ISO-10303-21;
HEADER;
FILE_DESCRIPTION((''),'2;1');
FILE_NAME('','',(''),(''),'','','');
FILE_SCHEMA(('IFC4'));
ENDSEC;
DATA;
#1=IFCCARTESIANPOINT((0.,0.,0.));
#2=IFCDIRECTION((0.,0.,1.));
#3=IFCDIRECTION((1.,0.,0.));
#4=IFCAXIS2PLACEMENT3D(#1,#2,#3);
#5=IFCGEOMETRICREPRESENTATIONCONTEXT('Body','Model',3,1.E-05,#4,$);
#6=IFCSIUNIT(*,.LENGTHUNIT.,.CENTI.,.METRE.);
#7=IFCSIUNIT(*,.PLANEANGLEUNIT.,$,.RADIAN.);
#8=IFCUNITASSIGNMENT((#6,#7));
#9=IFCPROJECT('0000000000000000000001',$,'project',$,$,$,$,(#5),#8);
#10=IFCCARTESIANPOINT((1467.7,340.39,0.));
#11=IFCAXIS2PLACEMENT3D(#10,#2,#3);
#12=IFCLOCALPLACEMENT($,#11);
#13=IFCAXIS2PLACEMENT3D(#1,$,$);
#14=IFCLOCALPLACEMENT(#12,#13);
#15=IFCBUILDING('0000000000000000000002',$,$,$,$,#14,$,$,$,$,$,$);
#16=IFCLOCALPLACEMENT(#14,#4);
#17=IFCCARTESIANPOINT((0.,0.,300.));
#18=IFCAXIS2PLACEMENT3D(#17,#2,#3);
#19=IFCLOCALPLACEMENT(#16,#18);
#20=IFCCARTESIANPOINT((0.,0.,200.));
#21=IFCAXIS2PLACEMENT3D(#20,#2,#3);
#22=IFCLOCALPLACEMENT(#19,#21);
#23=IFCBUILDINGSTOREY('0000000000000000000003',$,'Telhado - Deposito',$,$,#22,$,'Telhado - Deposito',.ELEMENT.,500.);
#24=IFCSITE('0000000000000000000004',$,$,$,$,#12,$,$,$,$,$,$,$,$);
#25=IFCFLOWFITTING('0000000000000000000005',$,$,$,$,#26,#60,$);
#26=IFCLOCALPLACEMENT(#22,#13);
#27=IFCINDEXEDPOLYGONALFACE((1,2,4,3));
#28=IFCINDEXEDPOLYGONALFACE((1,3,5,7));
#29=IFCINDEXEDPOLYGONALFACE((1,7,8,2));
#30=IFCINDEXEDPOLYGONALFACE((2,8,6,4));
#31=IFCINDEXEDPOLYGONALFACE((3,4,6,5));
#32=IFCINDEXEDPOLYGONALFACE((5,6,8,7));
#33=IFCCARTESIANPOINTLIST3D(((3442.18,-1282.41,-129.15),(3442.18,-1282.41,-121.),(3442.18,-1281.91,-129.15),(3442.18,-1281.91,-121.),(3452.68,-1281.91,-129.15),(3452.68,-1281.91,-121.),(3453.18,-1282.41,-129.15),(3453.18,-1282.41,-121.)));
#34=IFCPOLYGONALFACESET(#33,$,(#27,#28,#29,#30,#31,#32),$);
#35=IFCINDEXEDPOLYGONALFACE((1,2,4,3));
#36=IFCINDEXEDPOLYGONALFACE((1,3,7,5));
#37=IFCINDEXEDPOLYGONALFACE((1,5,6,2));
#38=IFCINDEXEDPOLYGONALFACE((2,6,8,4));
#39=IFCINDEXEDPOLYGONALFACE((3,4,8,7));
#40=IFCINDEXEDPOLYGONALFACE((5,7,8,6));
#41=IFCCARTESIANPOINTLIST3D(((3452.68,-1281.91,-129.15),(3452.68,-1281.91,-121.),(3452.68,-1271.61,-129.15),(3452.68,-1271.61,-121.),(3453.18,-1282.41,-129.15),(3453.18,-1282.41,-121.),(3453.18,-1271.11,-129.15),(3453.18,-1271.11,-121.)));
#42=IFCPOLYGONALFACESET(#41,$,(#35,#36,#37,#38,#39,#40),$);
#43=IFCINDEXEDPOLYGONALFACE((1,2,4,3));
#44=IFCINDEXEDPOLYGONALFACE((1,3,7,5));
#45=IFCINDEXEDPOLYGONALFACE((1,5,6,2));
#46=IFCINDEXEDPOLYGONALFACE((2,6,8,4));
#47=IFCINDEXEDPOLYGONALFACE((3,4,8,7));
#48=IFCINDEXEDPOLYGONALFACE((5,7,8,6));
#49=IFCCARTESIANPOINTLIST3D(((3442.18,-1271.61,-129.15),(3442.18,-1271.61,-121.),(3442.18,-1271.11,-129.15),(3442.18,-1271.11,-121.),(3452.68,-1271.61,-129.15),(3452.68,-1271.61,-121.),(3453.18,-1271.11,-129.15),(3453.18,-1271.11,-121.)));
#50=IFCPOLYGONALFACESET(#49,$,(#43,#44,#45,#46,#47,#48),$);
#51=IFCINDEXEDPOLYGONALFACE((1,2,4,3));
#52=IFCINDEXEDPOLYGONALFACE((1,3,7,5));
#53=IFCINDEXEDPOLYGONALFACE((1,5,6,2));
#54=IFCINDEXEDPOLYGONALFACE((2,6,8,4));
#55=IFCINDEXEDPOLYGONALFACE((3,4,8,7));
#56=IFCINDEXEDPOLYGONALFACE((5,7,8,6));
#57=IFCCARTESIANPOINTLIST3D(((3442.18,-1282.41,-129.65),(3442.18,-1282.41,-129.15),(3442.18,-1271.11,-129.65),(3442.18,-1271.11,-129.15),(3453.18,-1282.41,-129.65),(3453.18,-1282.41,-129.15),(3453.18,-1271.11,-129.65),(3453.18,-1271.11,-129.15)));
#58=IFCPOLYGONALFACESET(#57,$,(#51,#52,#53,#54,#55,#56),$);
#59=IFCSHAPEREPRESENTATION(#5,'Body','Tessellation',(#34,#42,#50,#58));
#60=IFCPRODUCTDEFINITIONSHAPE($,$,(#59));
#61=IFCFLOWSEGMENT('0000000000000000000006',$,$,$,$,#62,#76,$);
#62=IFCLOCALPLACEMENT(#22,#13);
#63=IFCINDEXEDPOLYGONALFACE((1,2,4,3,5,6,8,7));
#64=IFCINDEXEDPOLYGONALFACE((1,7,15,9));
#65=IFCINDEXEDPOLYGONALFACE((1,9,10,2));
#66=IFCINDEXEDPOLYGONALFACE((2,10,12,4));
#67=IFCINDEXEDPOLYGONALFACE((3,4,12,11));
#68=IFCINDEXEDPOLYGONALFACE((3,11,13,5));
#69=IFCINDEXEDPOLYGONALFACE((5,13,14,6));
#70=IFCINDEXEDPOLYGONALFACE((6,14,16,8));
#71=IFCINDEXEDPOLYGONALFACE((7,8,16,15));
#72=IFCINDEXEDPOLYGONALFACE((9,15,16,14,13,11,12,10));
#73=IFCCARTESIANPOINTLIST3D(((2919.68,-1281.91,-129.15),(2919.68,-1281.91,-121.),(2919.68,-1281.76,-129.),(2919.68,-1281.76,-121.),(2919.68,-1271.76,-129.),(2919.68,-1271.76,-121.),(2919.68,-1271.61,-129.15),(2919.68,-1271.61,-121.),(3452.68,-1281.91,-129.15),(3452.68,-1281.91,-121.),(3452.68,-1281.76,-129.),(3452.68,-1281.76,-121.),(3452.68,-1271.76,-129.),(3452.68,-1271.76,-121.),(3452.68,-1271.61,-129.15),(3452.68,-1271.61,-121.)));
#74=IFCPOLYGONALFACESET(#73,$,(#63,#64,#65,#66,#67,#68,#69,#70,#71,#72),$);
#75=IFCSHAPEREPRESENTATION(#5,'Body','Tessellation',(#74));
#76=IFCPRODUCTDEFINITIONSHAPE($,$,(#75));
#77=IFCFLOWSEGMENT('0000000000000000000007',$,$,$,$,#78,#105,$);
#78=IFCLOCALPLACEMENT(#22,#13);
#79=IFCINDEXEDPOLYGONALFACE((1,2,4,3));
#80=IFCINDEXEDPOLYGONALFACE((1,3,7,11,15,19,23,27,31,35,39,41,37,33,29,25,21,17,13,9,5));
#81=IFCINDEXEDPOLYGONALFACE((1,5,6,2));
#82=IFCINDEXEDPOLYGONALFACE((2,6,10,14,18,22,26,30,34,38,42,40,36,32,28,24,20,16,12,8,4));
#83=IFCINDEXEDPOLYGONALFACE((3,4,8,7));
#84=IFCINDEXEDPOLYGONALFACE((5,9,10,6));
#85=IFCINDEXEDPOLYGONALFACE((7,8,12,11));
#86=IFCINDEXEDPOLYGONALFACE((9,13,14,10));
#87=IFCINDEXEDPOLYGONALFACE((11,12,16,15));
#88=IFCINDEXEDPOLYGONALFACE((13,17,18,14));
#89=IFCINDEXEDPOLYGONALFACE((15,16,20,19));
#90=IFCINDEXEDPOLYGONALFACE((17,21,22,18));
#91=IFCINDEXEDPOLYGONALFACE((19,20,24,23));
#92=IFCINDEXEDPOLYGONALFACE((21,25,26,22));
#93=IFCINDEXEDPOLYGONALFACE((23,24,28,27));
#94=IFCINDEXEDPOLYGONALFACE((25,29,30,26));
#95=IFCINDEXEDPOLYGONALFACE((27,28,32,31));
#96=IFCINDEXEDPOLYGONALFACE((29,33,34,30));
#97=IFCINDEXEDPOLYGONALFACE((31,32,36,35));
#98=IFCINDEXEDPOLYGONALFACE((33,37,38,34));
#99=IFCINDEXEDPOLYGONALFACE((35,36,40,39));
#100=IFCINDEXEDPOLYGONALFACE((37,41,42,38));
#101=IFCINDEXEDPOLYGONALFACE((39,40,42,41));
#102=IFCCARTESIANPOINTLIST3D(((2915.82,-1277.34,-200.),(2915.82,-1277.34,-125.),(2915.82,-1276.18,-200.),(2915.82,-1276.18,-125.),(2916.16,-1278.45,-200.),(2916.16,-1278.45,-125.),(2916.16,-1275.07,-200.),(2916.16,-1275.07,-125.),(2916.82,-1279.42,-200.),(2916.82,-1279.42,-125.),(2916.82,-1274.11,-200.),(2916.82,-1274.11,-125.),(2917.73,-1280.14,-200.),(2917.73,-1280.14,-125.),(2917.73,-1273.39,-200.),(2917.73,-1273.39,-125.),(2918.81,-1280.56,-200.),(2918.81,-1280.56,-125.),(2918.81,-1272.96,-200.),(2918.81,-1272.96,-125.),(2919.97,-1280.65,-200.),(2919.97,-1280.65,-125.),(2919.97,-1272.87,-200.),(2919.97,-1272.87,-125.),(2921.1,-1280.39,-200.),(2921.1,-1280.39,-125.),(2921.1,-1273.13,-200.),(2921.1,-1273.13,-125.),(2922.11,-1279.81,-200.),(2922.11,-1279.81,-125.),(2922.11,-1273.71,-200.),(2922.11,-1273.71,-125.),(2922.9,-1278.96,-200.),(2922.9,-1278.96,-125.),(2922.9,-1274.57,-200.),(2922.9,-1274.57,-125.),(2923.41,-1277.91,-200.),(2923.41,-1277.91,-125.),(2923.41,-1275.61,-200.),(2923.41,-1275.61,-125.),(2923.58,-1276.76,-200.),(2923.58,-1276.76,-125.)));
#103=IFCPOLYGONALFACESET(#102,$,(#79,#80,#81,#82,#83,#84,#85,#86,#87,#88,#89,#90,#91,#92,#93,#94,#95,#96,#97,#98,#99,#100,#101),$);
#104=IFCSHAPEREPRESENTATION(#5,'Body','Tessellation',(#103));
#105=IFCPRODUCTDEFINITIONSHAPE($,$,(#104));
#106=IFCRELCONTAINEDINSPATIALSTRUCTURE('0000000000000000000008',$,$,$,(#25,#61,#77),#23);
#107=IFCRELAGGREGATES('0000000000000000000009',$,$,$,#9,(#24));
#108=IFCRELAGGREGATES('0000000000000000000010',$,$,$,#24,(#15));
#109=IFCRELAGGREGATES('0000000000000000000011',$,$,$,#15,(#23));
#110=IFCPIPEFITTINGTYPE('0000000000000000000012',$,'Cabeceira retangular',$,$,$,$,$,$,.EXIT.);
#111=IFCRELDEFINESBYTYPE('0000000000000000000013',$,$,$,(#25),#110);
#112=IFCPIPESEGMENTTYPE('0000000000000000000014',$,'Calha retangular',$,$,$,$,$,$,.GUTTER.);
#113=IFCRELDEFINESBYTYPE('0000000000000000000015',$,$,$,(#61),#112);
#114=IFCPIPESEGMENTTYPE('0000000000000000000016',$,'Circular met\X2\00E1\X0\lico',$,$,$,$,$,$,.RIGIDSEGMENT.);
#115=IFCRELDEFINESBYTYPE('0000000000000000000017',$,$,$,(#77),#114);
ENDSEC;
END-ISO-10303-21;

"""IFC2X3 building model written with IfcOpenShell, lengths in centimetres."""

from ifc_helpers import new_model, si_unit, frame, origin, origin_with_axes, origin_2d_with_axis, place, context, project, spatial, polyline, circle, outline, extrude, type_object, element, save


model = new_model("IFC2X3")

# Units and contexts
model_context = context("Model", 3, precision=1e-05, world=origin_with_axes(), identifier="Body")
ifc_project = project(units=[si_unit("LENGTHUNIT", "METRE", prefix="CENTI"), si_unit("PLANEANGLEUNIT", "RADIAN")], contexts=[model_context])

# Site, building, storey
site_placement = place(None, frame((1467.7, 340.39, 0.0), z_axis=(0.0, 0.0, 1.0), x_axis=(1.0, 0.0, 0.0)))
site = spatial("IfcSite", under=ifc_project, at=site_placement)
building_placement = place(site_placement, origin())
building = spatial("IfcBuilding", under=site, at=building_placement)
placement_1 = place(building_placement, origin_with_axes())
placement_2 = place(placement_1, frame((0.0, 0.0, 300.0), z_axis=(0.0, 0.0, 1.0), x_axis=(1.0, 0.0, 0.0)))
storey_placement = place(placement_2, frame((0.0, 0.0, 200.0), z_axis=(0.0, 0.0, 1.0), x_axis=(1.0, 0.0, 0.0)))
storey = spatial("IfcBuildingStorey", under=building, at=storey_placement, Name="Telhado - Deposito", LongName="Telhado - Deposito", CompositionType="ELEMENT", Elevation=500.0)

# Flow fitting
pipe_fitting_type = type_object("IfcPipeFittingType", Name="Cabeceira retangular", PredefinedType="EXIT")
flow_fitting_placement = place(storey_placement, frame((3447.68, -1276.76, -121.0), z_axis=(0.0, 0.0, 1.0), x_axis=(1.0, 0.0, 0.0)))
element("IfcFlowFitting", 1, at=flow_fitting_placement, inside=storey, type_object=pipe_fitting_type, context=model_context, shape_type="SolidModel", body=[
    extrude(outline(polyline([(0.0, 0.0), (11.0, 0.0), (10.5, 0.5), (0.0, 0.5), (0.0, 0.0)])), frame((-5.5, -5.65, -8.15), z_axis=(0.0, 0.0, 1.0), x_axis=(1.0, 0.0, 0.0)), (0.0, 0.0, 1.0), 8.15),
    extrude(outline(polyline([(0.0, 0.0), (11.3, 0.0), (10.8, 0.5), (0.5, 0.5), (0.0, 0.0)])), frame((5.5, -5.65, -8.15), z_axis=(0.0, 0.0, 1.0), x_axis=(0.0, 1.0, 0.0)), (0.0, 0.0, 1.0), 8.15),
    extrude(outline(polyline([(0.0, 0.0), (11.0, 0.0), (11.0, 0.5), (0.5, 0.5), (0.0, 0.0)])), frame((5.5, 5.65, -8.15), z_axis=(0.0, 0.0, 1.0), x_axis=(-1.0, 0.0, 0.0)), (0.0, 0.0, 1.0), 8.15),
    extrude(outline(polyline([(0.0, 0.0), (11.0, 0.0), (11.0, 11.3), (0.0, 11.3), (0.0, 0.0)])), frame((-5.5, -5.65, -8.15), z_axis=(0.0, 0.0, 1.0), x_axis=(1.0, 0.0, 0.0)), (0.0, 0.0, -1.0), 0.5),
])

# Flow segments
pipe_segment_type_1 = type_object("IfcPipeSegmentType", Name="Calha retangular", PredefinedType="GUTTER")
flow_segment_1_placement = place(storey_placement, frame((3186.18, -1276.76, -121.0), z_axis=(0.0, 0.0, 1.0), x_axis=(1.0, 0.0, 0.0)))
element("IfcFlowSegment", 2, at=flow_segment_1_placement, inside=storey, type_object=pipe_segment_type_1, context=model_context, shape_type="SolidModel", body=[
    extrude(outline(polyline([(0.0, 0.0), (8.0, 0.0), (8.0, 0.15), (-0.15, 0.15), (-0.15, -10.15), (8.0, -10.15), (8.0, -10.0), (0.0, -10.0), (0.0, 0.0)])), frame((266.5, 5.0, -8.0), z_axis=(-1.0, 0.0, 0.0), x_axis=(0.0, 0.0, 1.0)), (0.0, 0.0, 1.0), 533.0),
])
pipe_segment_type_2 = type_object("IfcPipeSegmentType", Name="Circular metálico", PredefinedType="RIGIDSEGMENT")
flow_segment_2_placement = place(storey_placement, frame((2919.68, -1276.76, -125.0), z_axis=(0.0, 0.0, 1.0), x_axis=(1.0, 0.0, 0.0)))
element("IfcFlowSegment", 3, at=flow_segment_2_placement, inside=storey, type_object=pipe_segment_type_2, context=model_context, shape_type="SolidModel", body=[
    extrude(circle(Radius=3.9, at=origin_2d_with_axis()), frame((0.0, 0.0, 0.0), z_axis=(0.0, 0.0, -1.0), x_axis=(1.0, 0.0, 0.0)), (0.0, 0.0, 1.0), 75.0),
])

save(model, "model.ifc")
